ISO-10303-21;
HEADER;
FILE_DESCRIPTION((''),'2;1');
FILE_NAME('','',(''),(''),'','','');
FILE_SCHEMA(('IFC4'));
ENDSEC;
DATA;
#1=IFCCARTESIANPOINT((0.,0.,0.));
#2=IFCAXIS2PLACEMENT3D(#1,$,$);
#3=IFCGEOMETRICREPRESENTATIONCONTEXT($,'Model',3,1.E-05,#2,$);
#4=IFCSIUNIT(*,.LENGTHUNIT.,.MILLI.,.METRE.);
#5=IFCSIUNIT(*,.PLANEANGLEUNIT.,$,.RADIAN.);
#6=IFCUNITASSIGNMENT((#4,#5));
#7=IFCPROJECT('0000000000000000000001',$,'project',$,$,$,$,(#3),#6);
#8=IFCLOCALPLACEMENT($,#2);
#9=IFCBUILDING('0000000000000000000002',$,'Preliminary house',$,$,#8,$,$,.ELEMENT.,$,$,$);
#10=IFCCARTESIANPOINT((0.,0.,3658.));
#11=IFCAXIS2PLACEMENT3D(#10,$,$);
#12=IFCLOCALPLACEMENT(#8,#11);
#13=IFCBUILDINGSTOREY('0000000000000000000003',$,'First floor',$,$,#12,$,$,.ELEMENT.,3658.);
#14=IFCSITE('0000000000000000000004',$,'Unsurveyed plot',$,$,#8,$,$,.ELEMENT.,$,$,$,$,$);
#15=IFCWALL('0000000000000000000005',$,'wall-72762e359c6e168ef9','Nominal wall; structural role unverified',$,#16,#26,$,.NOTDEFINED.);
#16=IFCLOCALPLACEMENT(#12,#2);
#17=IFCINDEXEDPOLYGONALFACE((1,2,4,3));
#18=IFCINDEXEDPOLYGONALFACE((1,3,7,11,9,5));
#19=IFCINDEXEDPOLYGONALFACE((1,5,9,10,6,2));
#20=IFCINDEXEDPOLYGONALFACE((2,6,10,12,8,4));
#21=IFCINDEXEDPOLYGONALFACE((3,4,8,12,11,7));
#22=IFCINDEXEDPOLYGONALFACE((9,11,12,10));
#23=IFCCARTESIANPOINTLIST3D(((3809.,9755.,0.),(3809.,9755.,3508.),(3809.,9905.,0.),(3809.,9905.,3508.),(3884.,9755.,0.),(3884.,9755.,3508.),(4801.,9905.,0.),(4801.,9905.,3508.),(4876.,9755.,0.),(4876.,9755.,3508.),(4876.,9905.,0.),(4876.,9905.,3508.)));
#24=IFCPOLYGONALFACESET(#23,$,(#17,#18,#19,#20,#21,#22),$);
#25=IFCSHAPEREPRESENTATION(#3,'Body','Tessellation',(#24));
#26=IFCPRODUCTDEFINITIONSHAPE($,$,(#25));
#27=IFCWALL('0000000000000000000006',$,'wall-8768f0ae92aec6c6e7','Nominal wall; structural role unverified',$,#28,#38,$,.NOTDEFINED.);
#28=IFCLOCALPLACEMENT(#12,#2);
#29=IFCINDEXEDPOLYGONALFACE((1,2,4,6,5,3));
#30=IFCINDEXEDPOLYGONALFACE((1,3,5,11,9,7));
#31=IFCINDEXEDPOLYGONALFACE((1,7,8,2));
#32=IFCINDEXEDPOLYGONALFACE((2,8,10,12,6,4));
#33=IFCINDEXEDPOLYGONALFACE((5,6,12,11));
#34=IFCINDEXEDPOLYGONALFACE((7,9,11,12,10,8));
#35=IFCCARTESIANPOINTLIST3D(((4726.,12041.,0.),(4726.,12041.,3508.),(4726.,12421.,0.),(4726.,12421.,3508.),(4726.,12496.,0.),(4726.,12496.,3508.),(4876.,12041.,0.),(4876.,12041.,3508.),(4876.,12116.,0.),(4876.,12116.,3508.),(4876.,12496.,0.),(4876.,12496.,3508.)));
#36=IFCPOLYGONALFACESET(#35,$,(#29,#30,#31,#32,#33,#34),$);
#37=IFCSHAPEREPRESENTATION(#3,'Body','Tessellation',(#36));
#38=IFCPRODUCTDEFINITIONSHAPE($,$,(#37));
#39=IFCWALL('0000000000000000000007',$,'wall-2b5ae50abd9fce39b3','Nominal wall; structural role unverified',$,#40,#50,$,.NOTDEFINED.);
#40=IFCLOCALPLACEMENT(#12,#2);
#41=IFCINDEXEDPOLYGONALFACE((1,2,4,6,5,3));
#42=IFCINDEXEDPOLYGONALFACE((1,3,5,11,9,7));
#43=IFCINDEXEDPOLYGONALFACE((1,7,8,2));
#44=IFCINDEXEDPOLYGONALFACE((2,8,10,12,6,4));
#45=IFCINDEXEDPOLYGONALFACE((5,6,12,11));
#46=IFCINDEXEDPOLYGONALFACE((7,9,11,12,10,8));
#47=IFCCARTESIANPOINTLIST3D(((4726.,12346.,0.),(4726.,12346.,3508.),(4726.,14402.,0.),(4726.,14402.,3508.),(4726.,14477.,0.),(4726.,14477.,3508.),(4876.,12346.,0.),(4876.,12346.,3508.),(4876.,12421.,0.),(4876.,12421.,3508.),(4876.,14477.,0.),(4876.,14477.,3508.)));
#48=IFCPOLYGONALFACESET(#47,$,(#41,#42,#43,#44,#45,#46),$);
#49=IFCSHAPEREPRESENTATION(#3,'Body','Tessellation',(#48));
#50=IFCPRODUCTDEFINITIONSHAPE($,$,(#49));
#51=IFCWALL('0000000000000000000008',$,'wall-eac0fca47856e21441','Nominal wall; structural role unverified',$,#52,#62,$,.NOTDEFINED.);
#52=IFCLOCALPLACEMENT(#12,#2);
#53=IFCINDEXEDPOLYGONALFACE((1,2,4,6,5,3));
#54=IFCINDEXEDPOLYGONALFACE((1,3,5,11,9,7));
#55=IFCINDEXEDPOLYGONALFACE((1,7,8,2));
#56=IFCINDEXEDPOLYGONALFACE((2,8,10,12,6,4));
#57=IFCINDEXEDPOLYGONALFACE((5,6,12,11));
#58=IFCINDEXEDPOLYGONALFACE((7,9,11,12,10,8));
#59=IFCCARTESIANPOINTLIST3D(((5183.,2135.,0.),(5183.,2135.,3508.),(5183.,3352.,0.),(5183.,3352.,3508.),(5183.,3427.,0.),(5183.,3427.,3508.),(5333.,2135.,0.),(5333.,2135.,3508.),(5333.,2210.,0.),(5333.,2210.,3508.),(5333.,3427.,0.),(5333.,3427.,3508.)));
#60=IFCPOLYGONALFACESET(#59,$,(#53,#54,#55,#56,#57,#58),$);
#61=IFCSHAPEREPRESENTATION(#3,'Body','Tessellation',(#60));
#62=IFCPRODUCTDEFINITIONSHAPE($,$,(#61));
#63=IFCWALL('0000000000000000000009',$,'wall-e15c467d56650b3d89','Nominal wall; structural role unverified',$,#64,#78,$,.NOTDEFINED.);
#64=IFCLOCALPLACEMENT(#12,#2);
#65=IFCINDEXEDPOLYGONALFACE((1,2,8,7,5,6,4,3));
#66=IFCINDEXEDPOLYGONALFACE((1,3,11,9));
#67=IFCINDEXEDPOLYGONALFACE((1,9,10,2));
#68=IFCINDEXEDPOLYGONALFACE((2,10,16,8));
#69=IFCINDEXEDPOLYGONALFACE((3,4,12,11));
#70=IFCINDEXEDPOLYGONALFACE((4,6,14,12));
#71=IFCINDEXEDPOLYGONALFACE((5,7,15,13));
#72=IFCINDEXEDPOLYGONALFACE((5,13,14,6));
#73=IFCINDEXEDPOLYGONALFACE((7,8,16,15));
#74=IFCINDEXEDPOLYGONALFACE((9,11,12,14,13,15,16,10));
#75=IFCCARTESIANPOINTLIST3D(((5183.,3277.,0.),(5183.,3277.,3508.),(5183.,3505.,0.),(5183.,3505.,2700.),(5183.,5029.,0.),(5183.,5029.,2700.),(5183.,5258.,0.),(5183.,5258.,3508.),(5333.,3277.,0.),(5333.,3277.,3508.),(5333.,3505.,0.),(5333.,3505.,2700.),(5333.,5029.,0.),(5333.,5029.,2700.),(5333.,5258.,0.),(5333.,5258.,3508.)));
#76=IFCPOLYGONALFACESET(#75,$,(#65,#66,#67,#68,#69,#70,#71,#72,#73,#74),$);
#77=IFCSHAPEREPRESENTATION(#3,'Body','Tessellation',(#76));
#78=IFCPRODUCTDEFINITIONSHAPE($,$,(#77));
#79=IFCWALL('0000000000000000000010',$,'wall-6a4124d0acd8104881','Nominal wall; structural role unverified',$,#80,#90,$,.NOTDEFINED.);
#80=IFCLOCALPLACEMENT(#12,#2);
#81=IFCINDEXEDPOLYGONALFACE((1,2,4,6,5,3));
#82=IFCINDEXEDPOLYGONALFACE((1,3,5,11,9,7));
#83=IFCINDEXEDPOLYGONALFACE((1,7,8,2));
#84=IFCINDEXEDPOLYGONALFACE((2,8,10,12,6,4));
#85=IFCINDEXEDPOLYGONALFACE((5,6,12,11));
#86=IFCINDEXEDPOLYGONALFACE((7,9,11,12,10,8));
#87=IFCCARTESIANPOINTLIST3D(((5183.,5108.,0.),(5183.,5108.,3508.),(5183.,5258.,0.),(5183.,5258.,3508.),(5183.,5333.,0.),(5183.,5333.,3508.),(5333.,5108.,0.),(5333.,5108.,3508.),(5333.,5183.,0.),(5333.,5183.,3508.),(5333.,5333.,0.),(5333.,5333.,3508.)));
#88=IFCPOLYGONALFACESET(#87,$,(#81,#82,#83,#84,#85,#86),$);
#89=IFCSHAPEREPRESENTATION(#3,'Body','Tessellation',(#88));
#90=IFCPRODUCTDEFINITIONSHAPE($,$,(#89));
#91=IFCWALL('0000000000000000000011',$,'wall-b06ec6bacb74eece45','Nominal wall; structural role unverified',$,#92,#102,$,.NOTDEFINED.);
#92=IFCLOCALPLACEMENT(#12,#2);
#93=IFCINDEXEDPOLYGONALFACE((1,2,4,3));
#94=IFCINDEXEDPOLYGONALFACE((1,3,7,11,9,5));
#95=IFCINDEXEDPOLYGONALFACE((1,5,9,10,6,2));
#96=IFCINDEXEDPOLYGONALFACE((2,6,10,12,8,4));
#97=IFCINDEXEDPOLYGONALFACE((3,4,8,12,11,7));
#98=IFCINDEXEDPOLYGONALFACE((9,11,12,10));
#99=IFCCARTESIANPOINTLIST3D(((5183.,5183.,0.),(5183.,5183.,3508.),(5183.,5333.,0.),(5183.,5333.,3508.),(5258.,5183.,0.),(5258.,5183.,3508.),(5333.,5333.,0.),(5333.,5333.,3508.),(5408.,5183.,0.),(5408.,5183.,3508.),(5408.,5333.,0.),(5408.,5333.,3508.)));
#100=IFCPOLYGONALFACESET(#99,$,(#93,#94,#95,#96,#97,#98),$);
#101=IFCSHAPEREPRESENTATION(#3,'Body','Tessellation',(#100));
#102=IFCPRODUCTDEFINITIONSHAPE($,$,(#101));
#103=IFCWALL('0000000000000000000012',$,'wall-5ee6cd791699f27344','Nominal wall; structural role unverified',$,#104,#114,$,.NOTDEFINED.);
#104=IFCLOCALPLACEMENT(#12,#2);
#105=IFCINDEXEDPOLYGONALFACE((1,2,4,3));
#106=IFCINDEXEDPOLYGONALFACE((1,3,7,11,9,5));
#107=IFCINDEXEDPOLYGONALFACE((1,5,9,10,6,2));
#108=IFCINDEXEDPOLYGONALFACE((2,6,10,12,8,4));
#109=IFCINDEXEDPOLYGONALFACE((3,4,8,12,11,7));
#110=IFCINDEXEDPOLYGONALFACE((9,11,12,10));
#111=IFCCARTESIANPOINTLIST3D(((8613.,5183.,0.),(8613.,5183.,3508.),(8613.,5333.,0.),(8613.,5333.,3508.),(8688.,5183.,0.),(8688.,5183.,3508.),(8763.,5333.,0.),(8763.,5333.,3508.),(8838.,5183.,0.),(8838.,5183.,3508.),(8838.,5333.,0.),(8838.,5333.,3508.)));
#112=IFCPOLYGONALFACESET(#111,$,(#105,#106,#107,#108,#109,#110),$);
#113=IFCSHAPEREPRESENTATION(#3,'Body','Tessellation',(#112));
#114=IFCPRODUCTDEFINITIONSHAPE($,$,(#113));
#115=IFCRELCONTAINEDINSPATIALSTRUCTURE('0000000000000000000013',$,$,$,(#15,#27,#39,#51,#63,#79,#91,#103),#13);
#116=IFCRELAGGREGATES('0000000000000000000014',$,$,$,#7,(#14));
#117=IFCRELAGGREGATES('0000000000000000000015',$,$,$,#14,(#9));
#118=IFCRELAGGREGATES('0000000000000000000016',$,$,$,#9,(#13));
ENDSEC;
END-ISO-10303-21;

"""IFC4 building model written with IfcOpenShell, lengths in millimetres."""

from ifc_helpers import new_model, si_unit, frame, origin, place, context, project, spatial, polyline, outline, extrude, element, save


model = new_model("IFC4")

# Units and contexts
model_context = context("Model", 3, precision=1e-05, world=origin())
ifc_project = project(units=[si_unit("LENGTHUNIT", "METRE", prefix="MILLI"), si_unit("PLANEANGLEUNIT", "RADIAN")], contexts=[model_context])

# Site, building, storey
placement_1 = place(None, origin())
site = spatial("IfcSite", under=ifc_project, at=placement_1, Name="Unsurveyed plot", CompositionType="ELEMENT")
building = spatial("IfcBuilding", under=site, at=placement_1, Name="Preliminary house", CompositionType="ELEMENT")
placement_2 = place(placement_1, frame((0.0, 0.0, 3658.0)))
storey = spatial("IfcBuildingStorey", under=building, at=placement_2, Name="First floor", CompositionType="ELEMENT", Elevation=3658.0)

# Wall
element("IfcWall", 1, at=placement_2, inside=storey, Name="wall-72762e359c6e168ef9", Description="Nominal wall; structural role unverified", PredefinedType="NOTDEFINED", context=model_context, shape_type="SweptSolid", body=[
    extrude(outline(polyline([(4801.0, 9905.0), (4876.0, 9905.0), (4876.0, 9755.0), (3884.0, 9755.0), (3809.0, 9755.0), (3809.0, 9905.0), (4801.0, 9905.0)])), origin(), (0.0, 0.0, 1.0), 3508.0),
])

# Walls
element("IfcWall", 2, at=placement_2, inside=storey, Name="wall-8768f0ae92aec6c6e7", Description="Nominal wall; structural role unverified", PredefinedType="NOTDEFINED", context=model_context, shape_type="SweptSolid", body=[
    extrude(outline(polyline([(4726.0, 12421.0), (4726.0, 12496.0), (4876.0, 12496.0), (4876.0, 12116.0), (4876.0, 12041.0), (4726.0, 12041.0), (4726.0, 12421.0)])), origin(), (0.0, 0.0, 1.0), 3508.0),
])
element("IfcWall", 3, at=placement_2, inside=storey, Name="wall-2b5ae50abd9fce39b3", Description="Nominal wall; structural role unverified", PredefinedType="NOTDEFINED", context=model_context, shape_type="SweptSolid", body=[
    extrude(outline(polyline([(4726.0, 14402.0), (4726.0, 14477.0), (4876.0, 14477.0), (4876.0, 12421.0), (4876.0, 12346.0), (4726.0, 12346.0), (4726.0, 14402.0)])), origin(), (0.0, 0.0, 1.0), 3508.0),
])

# Wall
element("IfcWall", 4, at=placement_2, inside=storey, Name="wall-eac0fca47856e21441", Description="Nominal wall; structural role unverified", PredefinedType="NOTDEFINED", context=model_context, shape_type="SweptSolid", body=[
    extrude(outline(polyline([(5183.0, 3352.0), (5183.0, 3427.0), (5333.0, 3427.0), (5333.0, 2210.0), (5333.0, 2135.0), (5183.0, 2135.0), (5183.0, 3352.0)])), origin(), (0.0, 0.0, 1.0), 3508.0),
])

# Wall, opening
wall_1 = element("IfcWall", 5, at=placement_2, inside=storey, Name="wall-e15c467d56650b3d89", Description="Nominal wall; structural role unverified", PredefinedType="NOTDEFINED", context=model_context, shape_type="SweptSolid", body=[
    extrude(outline(polyline([(5183.0, 5183.0), (5183.0, 5258.0), (5333.0, 5258.0), (5333.0, 3352.0), (5333.0, 3277.0), (5183.0, 3277.0), (5183.0, 5183.0)])), origin(), (0.0, 0.0, 1.0), 3508.0),
])
element("IfcOpeningElement", 6, at=placement_2, cuts=wall_1, PredefinedType="OPENING", context=model_context, shape_type="SweptSolid", body=[
    extrude(outline(polyline([(5708.0, 3505.0), (5708.0, 5029.0), (4808.0, 5029.0), (4808.0, 3505.0), (5708.0, 3505.0)])), origin(), (0.0, 0.0, 1.0), 2700.0),
])

# Wall
element("IfcWall", 7, at=placement_2, inside=storey, Name="wall-6a4124d0acd8104881", Description="Nominal wall; structural role unverified", PredefinedType="NOTDEFINED", context=model_context, shape_type="SweptSolid", body=[
    extrude(outline(polyline([(5183.0, 5258.0), (5183.0, 5333.0), (5333.0, 5333.0), (5333.0, 5183.0), (5333.0, 5108.0), (5183.0, 5108.0), (5183.0, 5258.0)])), origin(), (0.0, 0.0, 1.0), 3508.0),
])

# Wall
element("IfcWall", 8, at=placement_2, inside=storey, Name="wall-b06ec6bacb74eece45", Description="Nominal wall; structural role unverified", PredefinedType="NOTDEFINED", context=model_context, shape_type="SweptSolid", body=[
    extrude(outline(polyline([(5333.0, 5333.0), (5408.0, 5333.0), (5408.0, 5183.0), (5258.0, 5183.0), (5183.0, 5183.0), (5183.0, 5333.0), (5333.0, 5333.0)])), origin(), (0.0, 0.0, 1.0), 3508.0),
])

# Wall
element("IfcWall", 9, at=placement_2, inside=storey, Name="wall-5ee6cd791699f27344", Description="Nominal wall; structural role unverified", PredefinedType="NOTDEFINED", context=model_context, shape_type="SweptSolid", body=[
    extrude(outline(polyline([(8763.0, 5333.0), (8838.0, 5333.0), (8838.0, 5183.0), (8688.0, 5183.0), (8613.0, 5183.0), (8613.0, 5333.0), (8763.0, 5333.0)])), origin(), (0.0, 0.0, 1.0), 3508.0),
])

save(model, "model.ifc")
